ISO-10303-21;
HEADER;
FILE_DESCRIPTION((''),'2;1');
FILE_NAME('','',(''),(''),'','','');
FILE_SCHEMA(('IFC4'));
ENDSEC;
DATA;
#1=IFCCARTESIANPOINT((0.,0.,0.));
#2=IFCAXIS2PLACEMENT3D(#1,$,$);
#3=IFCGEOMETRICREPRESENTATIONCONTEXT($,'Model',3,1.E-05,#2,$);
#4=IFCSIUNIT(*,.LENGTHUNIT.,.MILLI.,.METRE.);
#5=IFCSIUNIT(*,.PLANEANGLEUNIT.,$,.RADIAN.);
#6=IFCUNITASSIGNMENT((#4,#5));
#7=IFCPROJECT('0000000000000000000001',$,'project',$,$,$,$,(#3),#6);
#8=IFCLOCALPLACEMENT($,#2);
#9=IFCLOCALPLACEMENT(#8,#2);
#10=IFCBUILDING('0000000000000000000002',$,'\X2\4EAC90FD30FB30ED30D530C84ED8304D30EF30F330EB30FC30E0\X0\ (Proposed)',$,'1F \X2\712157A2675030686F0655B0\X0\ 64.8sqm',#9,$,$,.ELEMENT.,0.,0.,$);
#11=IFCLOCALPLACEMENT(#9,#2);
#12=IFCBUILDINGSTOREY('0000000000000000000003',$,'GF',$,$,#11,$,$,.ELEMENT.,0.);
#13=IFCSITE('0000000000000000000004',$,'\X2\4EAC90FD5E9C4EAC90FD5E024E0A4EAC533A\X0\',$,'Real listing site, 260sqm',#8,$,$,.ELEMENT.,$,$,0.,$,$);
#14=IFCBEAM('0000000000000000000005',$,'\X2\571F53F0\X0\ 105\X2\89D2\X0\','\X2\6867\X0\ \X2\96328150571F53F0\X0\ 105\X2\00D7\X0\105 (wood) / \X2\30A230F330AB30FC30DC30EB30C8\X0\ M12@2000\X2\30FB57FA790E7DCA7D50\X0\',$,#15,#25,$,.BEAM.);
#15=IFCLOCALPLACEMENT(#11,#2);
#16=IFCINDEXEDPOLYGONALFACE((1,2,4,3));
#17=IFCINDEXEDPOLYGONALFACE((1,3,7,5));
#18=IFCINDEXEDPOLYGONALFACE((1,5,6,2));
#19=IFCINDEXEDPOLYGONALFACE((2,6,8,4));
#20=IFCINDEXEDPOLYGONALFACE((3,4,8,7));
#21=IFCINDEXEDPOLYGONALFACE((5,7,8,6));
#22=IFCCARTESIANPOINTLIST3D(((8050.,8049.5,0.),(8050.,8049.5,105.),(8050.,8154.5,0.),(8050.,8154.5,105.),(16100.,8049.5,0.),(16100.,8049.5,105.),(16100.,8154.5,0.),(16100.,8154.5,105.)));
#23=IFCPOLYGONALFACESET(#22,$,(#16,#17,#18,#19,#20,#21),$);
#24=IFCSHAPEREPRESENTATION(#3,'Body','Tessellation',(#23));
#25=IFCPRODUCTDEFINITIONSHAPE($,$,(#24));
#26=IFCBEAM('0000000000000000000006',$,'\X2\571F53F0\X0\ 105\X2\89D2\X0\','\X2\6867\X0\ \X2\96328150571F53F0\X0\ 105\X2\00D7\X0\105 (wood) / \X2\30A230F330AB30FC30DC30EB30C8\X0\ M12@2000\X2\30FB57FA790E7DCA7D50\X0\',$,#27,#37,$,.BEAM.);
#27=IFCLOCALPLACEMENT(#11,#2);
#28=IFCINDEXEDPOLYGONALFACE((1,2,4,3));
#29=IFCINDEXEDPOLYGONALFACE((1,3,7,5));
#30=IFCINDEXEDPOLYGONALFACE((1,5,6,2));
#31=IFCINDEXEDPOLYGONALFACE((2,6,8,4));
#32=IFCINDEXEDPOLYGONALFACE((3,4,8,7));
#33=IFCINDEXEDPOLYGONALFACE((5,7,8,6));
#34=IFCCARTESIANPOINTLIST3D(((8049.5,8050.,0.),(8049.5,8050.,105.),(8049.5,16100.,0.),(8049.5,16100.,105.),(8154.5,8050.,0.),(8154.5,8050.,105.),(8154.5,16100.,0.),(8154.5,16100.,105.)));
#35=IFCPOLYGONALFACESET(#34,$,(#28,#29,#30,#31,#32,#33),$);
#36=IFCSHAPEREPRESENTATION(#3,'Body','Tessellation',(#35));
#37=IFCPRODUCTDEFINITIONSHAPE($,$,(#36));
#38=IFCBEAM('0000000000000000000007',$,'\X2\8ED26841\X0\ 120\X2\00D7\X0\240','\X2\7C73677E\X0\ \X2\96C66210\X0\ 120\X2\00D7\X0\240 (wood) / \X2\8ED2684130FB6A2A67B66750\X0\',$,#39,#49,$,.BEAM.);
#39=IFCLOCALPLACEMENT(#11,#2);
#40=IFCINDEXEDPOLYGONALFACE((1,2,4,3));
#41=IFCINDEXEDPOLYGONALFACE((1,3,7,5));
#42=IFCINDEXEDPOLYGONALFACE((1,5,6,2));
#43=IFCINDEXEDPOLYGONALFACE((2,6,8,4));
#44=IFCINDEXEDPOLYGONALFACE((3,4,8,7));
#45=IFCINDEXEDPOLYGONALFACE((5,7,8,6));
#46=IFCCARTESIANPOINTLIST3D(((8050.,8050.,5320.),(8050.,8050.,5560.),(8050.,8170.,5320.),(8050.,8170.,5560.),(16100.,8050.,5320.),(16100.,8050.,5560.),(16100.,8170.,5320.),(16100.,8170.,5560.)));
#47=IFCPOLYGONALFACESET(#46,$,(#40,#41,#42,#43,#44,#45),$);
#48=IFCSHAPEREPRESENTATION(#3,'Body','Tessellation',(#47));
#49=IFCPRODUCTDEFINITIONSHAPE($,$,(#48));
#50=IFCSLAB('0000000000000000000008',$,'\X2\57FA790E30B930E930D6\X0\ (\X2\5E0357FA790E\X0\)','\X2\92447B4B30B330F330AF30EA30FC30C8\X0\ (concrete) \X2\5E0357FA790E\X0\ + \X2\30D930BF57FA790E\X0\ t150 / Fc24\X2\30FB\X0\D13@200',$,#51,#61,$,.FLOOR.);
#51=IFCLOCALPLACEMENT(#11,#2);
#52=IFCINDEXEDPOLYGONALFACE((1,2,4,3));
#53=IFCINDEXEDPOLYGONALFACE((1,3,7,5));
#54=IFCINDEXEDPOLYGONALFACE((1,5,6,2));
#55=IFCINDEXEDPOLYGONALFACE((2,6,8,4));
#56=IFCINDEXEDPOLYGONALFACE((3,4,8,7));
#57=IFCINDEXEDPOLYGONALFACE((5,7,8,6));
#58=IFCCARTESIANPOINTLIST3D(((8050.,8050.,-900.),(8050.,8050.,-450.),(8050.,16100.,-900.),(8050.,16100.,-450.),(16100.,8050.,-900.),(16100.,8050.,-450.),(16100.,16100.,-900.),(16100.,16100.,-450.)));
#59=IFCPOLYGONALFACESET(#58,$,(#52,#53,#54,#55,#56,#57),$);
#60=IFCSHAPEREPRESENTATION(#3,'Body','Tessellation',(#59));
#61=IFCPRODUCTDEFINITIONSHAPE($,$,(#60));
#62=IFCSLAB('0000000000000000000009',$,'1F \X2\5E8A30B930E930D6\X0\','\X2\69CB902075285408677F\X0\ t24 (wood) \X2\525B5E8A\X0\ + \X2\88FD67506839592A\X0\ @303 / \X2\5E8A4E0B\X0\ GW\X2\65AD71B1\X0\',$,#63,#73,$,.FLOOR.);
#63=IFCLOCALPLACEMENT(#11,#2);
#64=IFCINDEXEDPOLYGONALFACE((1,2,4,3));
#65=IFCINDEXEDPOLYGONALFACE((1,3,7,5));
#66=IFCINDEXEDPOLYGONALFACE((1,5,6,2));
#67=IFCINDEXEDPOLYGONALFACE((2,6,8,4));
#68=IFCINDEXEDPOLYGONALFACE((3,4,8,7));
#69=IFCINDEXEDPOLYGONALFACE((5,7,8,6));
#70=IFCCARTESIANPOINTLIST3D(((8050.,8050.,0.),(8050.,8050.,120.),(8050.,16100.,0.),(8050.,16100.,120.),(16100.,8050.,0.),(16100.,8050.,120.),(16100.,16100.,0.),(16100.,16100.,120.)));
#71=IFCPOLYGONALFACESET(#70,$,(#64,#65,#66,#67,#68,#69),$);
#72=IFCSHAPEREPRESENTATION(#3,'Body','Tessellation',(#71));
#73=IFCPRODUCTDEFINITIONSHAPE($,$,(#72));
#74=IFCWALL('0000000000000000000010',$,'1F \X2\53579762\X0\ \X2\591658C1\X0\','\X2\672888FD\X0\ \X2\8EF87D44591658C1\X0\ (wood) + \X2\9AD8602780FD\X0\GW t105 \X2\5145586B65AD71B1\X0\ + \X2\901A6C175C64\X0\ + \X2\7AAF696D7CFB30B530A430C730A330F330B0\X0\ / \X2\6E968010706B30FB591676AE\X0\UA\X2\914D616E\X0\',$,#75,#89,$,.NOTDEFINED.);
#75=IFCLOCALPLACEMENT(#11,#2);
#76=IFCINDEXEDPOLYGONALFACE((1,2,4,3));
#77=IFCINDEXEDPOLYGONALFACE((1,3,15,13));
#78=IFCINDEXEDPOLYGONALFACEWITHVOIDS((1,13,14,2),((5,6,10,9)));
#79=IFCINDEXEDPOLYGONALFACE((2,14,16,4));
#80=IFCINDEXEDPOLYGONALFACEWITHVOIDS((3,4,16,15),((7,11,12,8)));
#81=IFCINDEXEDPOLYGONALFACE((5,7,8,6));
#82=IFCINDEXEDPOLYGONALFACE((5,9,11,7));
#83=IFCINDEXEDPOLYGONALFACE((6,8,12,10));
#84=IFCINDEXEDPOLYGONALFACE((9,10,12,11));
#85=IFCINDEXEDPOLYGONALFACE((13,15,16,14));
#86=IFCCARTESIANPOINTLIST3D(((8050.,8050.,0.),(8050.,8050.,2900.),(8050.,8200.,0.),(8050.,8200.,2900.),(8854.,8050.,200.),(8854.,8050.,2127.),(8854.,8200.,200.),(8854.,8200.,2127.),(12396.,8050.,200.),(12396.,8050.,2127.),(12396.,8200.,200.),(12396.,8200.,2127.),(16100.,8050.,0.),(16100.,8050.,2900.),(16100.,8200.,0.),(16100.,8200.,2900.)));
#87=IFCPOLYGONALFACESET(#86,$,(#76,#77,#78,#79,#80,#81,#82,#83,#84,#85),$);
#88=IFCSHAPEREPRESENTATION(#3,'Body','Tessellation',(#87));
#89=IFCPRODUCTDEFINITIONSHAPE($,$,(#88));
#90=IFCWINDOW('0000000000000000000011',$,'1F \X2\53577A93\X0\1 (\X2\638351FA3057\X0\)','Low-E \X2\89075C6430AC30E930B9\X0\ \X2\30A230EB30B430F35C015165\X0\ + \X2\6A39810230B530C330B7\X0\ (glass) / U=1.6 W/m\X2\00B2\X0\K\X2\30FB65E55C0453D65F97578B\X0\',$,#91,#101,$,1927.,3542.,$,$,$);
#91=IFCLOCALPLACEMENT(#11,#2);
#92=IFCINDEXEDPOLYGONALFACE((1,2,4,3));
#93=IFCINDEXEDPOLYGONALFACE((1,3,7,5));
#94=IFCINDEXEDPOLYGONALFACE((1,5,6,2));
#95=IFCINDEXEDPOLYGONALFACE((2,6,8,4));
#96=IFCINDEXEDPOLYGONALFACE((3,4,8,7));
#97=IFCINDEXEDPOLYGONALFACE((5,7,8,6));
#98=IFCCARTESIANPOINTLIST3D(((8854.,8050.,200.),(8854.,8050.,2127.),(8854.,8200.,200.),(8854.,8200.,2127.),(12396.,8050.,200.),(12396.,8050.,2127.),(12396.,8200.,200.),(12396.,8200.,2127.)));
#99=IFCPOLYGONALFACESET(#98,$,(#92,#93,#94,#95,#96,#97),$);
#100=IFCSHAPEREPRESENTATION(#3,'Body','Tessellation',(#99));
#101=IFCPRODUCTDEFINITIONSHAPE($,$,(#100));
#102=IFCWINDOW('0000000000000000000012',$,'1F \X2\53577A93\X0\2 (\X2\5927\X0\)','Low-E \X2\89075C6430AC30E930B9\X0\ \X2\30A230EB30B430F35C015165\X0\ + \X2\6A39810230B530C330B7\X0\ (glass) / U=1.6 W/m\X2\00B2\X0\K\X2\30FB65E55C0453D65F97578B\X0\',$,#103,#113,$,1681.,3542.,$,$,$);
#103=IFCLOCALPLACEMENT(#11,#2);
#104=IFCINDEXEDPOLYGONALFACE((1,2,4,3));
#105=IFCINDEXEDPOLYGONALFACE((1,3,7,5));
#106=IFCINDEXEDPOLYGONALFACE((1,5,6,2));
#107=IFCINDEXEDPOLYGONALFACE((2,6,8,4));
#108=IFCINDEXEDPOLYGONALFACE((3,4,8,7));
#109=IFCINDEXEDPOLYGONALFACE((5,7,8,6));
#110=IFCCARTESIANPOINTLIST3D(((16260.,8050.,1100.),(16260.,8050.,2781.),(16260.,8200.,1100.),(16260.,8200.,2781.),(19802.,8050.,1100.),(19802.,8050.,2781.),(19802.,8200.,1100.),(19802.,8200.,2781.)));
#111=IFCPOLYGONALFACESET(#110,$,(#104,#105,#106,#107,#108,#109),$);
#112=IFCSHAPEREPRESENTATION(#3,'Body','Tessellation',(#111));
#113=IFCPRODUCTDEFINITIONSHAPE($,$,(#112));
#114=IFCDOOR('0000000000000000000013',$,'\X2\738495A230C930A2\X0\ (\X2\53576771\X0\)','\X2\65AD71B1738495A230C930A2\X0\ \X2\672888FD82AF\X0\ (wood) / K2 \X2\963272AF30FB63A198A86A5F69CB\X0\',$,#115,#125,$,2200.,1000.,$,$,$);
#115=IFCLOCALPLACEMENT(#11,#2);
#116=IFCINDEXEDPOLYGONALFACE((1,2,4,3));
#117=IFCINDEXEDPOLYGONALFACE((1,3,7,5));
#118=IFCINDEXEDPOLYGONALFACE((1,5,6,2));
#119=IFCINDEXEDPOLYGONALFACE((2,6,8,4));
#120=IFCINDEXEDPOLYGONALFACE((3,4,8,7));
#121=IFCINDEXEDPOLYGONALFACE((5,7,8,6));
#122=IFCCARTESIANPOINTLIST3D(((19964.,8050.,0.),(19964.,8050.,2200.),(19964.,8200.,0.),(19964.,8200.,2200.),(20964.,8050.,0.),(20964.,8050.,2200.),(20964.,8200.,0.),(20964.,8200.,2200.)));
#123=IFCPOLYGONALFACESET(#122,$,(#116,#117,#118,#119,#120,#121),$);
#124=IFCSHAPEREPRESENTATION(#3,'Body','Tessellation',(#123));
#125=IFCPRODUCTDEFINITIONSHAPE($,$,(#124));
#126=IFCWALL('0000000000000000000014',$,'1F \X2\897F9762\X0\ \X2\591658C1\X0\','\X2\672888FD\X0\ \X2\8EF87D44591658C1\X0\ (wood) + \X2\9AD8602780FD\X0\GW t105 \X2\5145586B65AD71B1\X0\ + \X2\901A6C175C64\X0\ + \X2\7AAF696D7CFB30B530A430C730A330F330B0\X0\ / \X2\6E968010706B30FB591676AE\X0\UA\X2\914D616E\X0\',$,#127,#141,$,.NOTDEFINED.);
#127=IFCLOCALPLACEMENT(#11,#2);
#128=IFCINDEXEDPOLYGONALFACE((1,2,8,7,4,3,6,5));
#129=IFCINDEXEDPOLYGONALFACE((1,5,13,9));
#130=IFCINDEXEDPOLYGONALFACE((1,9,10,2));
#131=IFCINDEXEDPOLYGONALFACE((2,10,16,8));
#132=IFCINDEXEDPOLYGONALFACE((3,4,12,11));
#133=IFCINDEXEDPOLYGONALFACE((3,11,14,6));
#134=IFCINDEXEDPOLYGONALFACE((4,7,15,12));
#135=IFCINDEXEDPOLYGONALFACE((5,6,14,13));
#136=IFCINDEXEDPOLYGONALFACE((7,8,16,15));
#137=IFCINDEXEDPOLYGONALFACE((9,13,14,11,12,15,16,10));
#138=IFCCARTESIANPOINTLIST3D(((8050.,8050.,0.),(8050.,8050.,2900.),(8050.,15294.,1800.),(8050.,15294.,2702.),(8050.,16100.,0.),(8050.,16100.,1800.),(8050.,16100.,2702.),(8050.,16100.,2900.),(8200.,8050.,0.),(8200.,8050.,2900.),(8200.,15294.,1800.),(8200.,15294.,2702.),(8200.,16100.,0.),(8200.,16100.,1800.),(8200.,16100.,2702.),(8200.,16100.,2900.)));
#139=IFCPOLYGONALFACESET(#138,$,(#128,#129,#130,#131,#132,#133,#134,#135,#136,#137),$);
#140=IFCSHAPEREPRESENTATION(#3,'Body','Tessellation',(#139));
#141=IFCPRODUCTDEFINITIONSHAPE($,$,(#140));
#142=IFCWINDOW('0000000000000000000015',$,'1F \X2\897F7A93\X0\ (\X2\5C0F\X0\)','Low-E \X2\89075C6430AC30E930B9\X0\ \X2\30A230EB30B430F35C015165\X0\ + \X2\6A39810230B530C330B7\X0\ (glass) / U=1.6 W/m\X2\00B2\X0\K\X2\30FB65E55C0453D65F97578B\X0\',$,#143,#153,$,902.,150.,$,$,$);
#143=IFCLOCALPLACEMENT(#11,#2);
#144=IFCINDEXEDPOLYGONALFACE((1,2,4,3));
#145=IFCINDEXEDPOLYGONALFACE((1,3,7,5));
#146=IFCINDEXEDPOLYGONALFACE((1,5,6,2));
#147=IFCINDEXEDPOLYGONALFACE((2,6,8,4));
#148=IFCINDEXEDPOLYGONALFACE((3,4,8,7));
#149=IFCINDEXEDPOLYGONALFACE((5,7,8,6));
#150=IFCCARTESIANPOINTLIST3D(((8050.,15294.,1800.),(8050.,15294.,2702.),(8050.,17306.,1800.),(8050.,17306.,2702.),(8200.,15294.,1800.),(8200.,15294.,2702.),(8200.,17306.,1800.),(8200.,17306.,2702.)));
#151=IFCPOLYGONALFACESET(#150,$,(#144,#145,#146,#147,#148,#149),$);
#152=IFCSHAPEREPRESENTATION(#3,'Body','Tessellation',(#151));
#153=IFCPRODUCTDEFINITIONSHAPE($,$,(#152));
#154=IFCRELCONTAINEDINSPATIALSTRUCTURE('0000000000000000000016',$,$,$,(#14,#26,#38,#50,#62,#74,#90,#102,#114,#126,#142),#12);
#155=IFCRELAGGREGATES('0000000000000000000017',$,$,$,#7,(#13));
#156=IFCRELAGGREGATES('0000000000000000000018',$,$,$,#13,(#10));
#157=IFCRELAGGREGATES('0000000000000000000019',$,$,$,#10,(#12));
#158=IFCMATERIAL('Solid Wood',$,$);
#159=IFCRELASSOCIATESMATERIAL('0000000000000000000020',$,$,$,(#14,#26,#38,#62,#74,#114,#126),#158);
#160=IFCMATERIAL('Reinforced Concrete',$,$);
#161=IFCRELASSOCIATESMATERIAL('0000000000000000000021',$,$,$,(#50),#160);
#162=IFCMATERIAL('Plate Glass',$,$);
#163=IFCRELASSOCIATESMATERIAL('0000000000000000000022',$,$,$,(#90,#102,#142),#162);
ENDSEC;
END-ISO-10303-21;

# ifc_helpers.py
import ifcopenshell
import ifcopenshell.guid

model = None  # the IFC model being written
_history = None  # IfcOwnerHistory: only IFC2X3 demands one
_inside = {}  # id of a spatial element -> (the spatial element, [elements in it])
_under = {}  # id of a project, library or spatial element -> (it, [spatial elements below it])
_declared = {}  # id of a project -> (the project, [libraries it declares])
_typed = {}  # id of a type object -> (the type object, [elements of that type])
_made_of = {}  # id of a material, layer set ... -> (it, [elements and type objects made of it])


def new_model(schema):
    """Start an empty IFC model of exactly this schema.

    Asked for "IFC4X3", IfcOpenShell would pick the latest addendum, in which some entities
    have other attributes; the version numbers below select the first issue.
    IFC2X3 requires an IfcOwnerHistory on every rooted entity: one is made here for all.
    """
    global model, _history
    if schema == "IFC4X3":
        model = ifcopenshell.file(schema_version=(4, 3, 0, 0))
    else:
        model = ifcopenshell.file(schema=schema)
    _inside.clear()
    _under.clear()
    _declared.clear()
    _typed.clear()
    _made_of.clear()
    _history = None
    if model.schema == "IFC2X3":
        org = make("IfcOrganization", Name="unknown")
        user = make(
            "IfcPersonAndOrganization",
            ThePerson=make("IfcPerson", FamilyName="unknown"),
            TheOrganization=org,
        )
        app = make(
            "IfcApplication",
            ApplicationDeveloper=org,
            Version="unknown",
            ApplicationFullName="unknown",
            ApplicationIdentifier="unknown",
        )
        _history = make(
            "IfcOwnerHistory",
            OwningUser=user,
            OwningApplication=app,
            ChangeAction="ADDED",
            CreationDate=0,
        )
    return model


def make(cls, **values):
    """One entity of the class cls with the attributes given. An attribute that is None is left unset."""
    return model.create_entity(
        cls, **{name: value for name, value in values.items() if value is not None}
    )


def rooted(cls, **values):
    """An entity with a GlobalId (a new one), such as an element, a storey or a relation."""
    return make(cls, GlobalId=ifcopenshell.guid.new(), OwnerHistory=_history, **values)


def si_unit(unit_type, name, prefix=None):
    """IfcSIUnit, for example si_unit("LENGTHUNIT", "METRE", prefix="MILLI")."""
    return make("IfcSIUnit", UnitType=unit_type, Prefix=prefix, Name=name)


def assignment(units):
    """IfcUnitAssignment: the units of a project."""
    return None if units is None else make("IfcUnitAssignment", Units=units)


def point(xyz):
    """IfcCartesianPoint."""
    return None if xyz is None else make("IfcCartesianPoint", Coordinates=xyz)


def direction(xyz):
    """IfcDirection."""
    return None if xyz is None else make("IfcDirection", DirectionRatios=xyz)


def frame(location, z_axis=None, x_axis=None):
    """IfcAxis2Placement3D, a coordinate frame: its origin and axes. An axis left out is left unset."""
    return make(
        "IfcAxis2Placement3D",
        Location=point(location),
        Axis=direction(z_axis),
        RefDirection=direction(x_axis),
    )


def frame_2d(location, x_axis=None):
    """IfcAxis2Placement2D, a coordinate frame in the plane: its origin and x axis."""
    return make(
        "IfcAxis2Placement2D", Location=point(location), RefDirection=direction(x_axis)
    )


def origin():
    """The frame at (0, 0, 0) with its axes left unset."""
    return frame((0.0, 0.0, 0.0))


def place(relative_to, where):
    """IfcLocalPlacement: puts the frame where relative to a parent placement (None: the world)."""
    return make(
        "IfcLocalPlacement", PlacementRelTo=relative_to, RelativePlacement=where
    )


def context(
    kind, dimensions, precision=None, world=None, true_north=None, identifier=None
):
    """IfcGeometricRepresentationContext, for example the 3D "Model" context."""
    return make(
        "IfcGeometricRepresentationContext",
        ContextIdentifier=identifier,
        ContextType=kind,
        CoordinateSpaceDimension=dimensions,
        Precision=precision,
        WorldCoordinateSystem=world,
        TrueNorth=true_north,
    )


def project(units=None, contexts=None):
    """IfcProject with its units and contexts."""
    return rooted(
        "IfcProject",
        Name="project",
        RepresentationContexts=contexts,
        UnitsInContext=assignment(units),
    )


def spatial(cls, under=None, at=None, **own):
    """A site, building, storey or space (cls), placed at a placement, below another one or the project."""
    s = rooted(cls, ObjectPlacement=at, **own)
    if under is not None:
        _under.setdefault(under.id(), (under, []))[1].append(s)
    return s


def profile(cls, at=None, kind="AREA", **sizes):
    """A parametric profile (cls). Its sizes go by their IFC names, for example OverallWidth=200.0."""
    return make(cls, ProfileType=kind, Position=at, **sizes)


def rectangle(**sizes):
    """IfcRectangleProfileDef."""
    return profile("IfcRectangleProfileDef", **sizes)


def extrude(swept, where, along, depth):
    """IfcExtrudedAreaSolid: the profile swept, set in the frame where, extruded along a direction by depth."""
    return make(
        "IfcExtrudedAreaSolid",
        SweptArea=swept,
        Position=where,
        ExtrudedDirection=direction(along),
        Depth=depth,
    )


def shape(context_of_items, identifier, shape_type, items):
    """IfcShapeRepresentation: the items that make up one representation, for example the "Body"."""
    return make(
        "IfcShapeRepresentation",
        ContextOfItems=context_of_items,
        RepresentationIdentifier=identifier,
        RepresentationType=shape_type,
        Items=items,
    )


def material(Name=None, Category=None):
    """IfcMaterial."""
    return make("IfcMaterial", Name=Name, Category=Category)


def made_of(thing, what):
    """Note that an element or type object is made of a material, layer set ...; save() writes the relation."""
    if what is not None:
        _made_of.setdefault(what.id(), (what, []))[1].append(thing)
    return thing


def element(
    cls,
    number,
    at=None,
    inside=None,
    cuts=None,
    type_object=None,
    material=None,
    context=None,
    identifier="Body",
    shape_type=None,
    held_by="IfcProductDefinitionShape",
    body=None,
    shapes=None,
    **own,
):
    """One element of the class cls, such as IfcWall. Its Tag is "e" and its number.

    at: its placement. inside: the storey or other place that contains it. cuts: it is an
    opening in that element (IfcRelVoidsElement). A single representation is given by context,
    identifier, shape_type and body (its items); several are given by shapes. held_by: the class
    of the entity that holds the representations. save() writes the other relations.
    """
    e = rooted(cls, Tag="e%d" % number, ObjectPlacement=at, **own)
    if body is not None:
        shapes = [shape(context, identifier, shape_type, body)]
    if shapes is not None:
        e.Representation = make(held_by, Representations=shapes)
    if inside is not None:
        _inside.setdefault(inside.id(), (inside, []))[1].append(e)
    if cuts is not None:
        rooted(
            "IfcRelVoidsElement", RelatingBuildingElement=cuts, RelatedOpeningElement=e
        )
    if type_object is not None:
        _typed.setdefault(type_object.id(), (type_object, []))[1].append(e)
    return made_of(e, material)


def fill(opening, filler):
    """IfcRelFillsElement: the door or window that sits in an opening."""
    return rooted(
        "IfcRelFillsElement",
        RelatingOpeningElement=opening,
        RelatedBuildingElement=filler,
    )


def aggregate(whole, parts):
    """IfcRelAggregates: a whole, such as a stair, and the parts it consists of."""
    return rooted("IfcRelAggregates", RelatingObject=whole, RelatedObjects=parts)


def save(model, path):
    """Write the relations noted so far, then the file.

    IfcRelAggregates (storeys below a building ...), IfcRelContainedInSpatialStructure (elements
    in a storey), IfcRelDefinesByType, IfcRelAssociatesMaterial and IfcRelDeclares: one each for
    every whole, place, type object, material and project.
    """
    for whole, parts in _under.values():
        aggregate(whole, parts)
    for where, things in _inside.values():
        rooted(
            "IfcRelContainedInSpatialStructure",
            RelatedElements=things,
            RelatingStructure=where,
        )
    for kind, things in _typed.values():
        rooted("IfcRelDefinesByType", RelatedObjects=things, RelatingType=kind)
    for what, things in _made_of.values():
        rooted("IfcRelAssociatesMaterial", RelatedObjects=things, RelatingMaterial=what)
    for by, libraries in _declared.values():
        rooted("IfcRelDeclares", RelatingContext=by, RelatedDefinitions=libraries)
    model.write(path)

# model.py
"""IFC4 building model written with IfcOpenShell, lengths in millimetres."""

from ifc_helpers import new_model, si_unit, frame, frame_2d, origin, place, context, project, spatial, rectangle, extrude, material, element, fill, save


model = new_model("IFC4")

# Units and contexts
model_context = context("Model", 3, precision=1e-05, world=origin())
ifc_project = project(units=[si_unit("LENGTHUNIT", "METRE", prefix="MILLI"), si_unit("PLANEANGLEUNIT", "RADIAN")], contexts=[model_context])

# Site, building, storey
site_placement = place(None, origin())
site = spatial("IfcSite", under=ifc_project, at=site_placement, Name="京都府京都市上京区", ObjectType="Real listing site, 260sqm", CompositionType="ELEMENT", RefElevation=0.0)
building_placement = place(site_placement, origin())
building = spatial("IfcBuilding", under=site, at=building_placement, Name="京都・ロフト付きワンルーム (Proposed)", ObjectType="1F 無垢材と漆喰 64.8sqm", CompositionType="ELEMENT", ElevationOfRefHeight=0.0, ElevationOfTerrain=0.0)
storey_placement = place(building_placement, origin())
storey = spatial("IfcBuildingStorey", under=building, at=storey_placement, Name="GF", CompositionType="ELEMENT", Elevation=0.0)

# Shared definitions
ifc_material_1 = material(Name="Solid Wood")

# Beams
beam_1_placement = place(storey_placement, frame((4025.0, 4025.0, 0.0)))
element("IfcBeam", 1, at=beam_1_placement, inside=storey, material=ifc_material_1, Name="土台 105角", Description="桧 防腐土台 105×105 (wood) / アンカーボルト M12@2000・基礎緊結", PredefinedType="BEAM", context=model_context, shape_type="SweptSolid", body=[
    extrude(rectangle(XDim=8050.0, YDim=105.0, at=frame_2d((4025.0, 52.0))), frame((4025.0, 4025.0, 0.0)), (0.0, 0.0, 1.0), 105.0),
])
beam_2_placement = place(storey_placement, frame((4025.0, 4025.0, 0.0)))
element("IfcBeam", 2, at=beam_2_placement, inside=storey, material=ifc_material_1, Name="土台 105角", Description="桧 防腐土台 105×105 (wood) / アンカーボルト M12@2000・基礎緊結", PredefinedType="BEAM", context=model_context, shape_type="SweptSolid", body=[
    extrude(rectangle(XDim=105.0, YDim=8050.0, at=frame_2d((52.0, 4025.0))), frame((4025.0, 4025.0, 0.0)), (0.0, 0.0, 1.0), 105.0),
])
beam_3_placement = place(storey_placement, frame((4025.0, 4025.0, 2660.0)))
element("IfcBeam", 3, at=beam_3_placement, inside=storey, material=ifc_material_1, Name="軒桁 120×240", Description="米松 集成 120×240 (wood) / 軒桁・横架材", PredefinedType="BEAM", context=model_context, shape_type="SweptSolid", body=[
    extrude(rectangle(XDim=8050.0, YDim=120.0, at=frame_2d((4025.0, 60.0))), frame((4025.0, 4025.0, 2660.0)), (0.0, 0.0, 1.0), 240.0),
])

# Slabs
ifc_material_2 = material(Name="Reinforced Concrete")
slab_1_placement = place(storey_placement, frame((4025.0, 4025.0, -450.0)))
element("IfcSlab", 4, at=slab_1_placement, inside=storey, material=ifc_material_2, Name="基礎スラブ (布基礎)", Description="鉄筋コンクリート (concrete) 布基礎 + ベタ基礎 t150 / Fc24・D13@200", PredefinedType="FLOOR", context=model_context, shape_type="SweptSolid", body=[
    extrude(rectangle(XDim=8050.0, YDim=8050.0, at=frame_2d((4025.0, 4025.0))), frame((4025.0, 4025.0, -450.0)), (0.0, 0.0, 1.0), 450.0),
])
slab_2_placement = place(storey_placement, frame((4025.0, 4025.0, 0.0)))
element("IfcSlab", 5, at=slab_2_placement, inside=storey, material=ifc_material_1, Name="1F 床スラブ", Description="構造用合板 t24 (wood) 剛床 + 製材根太 @303 / 床下 GW断熱", PredefinedType="FLOOR", context=model_context, shape_type="SweptSolid", body=[
    extrude(rectangle(XDim=8050.0, YDim=8050.0, at=frame_2d((4025.0, 4025.0))), frame((4025.0, 4025.0, 0.0)), (0.0, 0.0, 1.0), 120.0),
])

# Wall, openings, windows, door
wall_1_placement = place(storey_placement, frame((4025.0, 4025.0, 0.0)))
wall_1 = element("IfcWall", 6, at=wall_1_placement, inside=storey, material=ifc_material_1, Name="1F 南面 外壁", Description="木製 軸組外壁 (wood) + 高性能GW t105 充填断熱 + 通気層 + 窯業系サイディング / 準耐火・外皮UA配慮", PredefinedType="NOTDEFINED", context=model_context, shape_type="SweptSolid", body=[
    extrude(rectangle(XDim=8050.0, YDim=150.0, at=frame_2d((4025.0, 75.0))), frame((4025.0, 4025.0, 0.0)), (0.0, 0.0, 1.0), 2900.0),
])
opening_1_placement = place(storey_placement, frame((4427.0, 4025.0, 100.0)))
opening_1 = element("IfcOpeningElement", 7, at=opening_1_placement, cuts=wall_1, PredefinedType="NOTDEFINED", context=model_context, shape_type="SweptSolid", body=[
    extrude(rectangle(XDim=3542.0, YDim=150.0, at=frame_2d((1771.0, 75.0))), frame((4427.0, 4025.0, 100.0)), (0.0, 0.0, 1.0), 1927.0),
])
opening_2_placement = place(storey_placement, frame((8130.0, 4025.0, 550.0)))
opening_2 = element("IfcOpeningElement", 8, at=opening_2_placement, cuts=wall_1, PredefinedType="NOTDEFINED", context=model_context, shape_type="SweptSolid", body=[
    extrude(rectangle(XDim=3542.0, YDim=150.0, at=frame_2d((1771.0, 75.0))), frame((8130.0, 4025.0, 550.0)), (0.0, 0.0, 1.0), 1681.0),
])
opening_3_placement = place(storey_placement, frame((9982.0, 4025.0, 0.0)))
opening_3 = element("IfcOpeningElement", 9, at=opening_3_placement, cuts=wall_1, PredefinedType="NOTDEFINED", context=model_context, shape_type="SweptSolid", body=[
    extrude(rectangle(XDim=1000.0, YDim=150.0, at=frame_2d((500.0, 75.0))), frame((9982.0, 4025.0, 0.0)), (0.0, 0.0, 1.0), 2200.0),
])
ifc_material_3 = material(Name="Plate Glass")
window_1_placement = place(storey_placement, frame((4427.0, 4025.0, 100.0)))
window_1 = element("IfcWindow", 10, at=window_1_placement, inside=storey, material=ifc_material_3, Name="1F 南窓1 (掃出し)", Description="Low-E 複層ガラス アルゴン封入 + 樹脂サッシ (glass) / U=1.6 W/m²K・日射取得型", OverallHeight=1927.0, OverallWidth=3542.0, context=model_context, shape_type="SweptSolid", body=[
    extrude(rectangle(XDim=3542.0, YDim=150.0, at=frame_2d((1771.0, 75.0))), frame((4427.0, 4025.0, 100.0)), (0.0, 0.0, 1.0), 1927.0),
])
fill(opening_1, window_1)
window_2_placement = place(storey_placement, frame((8130.0, 4025.0, 550.0)))
window_2 = element("IfcWindow", 11, at=window_2_placement, inside=storey, material=ifc_material_3, Name="1F 南窓2 (大)", Description="Low-E 複層ガラス アルゴン封入 + 樹脂サッシ (glass) / U=1.6 W/m²K・日射取得型", OverallHeight=1681.0, OverallWidth=3542.0, context=model_context, shape_type="SweptSolid", body=[
    extrude(rectangle(XDim=3542.0, YDim=150.0, at=frame_2d((1771.0, 75.0))), frame((8130.0, 4025.0, 550.0)), (0.0, 0.0, 1.0), 1681.0),
])
fill(opening_2, window_2)
door_placement = place(storey_placement, frame((9982.0, 4025.0, 0.0)))
door = element("IfcDoor", 12, at=door_placement, inside=storey, material=ifc_material_1, Name="玄関ドア (南東)", Description="断熱玄関ドア 木製芯 (wood) / K2 防犯・採風機構", OverallHeight=2200.0, OverallWidth=1000.0, context=model_context, shape_type="SweptSolid", body=[
    extrude(rectangle(XDim=1000.0, YDim=150.0, at=frame_2d((500.0, 75.0))), frame((9982.0, 4025.0, 0.0)), (0.0, 0.0, 1.0), 2200.0),
])
fill(opening_3, door)

# Wall, opening, window
wall_2_placement = place(storey_placement, frame((4025.0, 4025.0, 0.0)))
wall_2 = element("IfcWall", 13, at=wall_2_placement, inside=storey, material=ifc_material_1, Name="1F 西面 外壁", Description="木製 軸組外壁 (wood) + 高性能GW t105 充填断熱 + 通気層 + 窯業系サイディング / 準耐火・外皮UA配慮", PredefinedType="NOTDEFINED", context=model_context, shape_type="SweptSolid", body=[
    extrude(rectangle(XDim=150.0, YDim=8050.0, at=frame_2d((75.0, 4025.0))), frame((4025.0, 4025.0, 0.0)), (0.0, 0.0, 1.0), 2900.0),
])
opening_4_placement = place(storey_placement, frame((4025.0, 7647.0, 900.0)))
opening_4 = element("IfcOpeningElement", 14, at=opening_4_placement, cuts=wall_2, PredefinedType="NOTDEFINED", context=model_context, shape_type="SweptSolid", body=[
    extrude(rectangle(XDim=150.0, YDim=2012.0, at=frame_2d((75.0, 1006.0))), frame((4025.0, 7647.0, 900.0)), (0.0, 0.0, 1.0), 902.0),
])
window_3_placement = place(storey_placement, frame((4025.0, 7647.0, 900.0)))
window_3 = element("IfcWindow", 15, at=window_3_placement, inside=storey, material=ifc_material_3, Name="1F 西窓 (小)", Description="Low-E 複層ガラス アルゴン封入 + 樹脂サッシ (glass) / U=1.6 W/m²K・日射取得型", OverallHeight=902.0, OverallWidth=150.0, context=model_context, shape_type="SweptSolid", body=[
    extrude(rectangle(XDim=150.0, YDim=2012.0, at=frame_2d((75.0, 1006.0))), frame((4025.0, 7647.0, 900.0)), (0.0, 0.0, 1.0), 902.0),
])
fill(opening_4, window_3)

save(model, "model.ifc")
